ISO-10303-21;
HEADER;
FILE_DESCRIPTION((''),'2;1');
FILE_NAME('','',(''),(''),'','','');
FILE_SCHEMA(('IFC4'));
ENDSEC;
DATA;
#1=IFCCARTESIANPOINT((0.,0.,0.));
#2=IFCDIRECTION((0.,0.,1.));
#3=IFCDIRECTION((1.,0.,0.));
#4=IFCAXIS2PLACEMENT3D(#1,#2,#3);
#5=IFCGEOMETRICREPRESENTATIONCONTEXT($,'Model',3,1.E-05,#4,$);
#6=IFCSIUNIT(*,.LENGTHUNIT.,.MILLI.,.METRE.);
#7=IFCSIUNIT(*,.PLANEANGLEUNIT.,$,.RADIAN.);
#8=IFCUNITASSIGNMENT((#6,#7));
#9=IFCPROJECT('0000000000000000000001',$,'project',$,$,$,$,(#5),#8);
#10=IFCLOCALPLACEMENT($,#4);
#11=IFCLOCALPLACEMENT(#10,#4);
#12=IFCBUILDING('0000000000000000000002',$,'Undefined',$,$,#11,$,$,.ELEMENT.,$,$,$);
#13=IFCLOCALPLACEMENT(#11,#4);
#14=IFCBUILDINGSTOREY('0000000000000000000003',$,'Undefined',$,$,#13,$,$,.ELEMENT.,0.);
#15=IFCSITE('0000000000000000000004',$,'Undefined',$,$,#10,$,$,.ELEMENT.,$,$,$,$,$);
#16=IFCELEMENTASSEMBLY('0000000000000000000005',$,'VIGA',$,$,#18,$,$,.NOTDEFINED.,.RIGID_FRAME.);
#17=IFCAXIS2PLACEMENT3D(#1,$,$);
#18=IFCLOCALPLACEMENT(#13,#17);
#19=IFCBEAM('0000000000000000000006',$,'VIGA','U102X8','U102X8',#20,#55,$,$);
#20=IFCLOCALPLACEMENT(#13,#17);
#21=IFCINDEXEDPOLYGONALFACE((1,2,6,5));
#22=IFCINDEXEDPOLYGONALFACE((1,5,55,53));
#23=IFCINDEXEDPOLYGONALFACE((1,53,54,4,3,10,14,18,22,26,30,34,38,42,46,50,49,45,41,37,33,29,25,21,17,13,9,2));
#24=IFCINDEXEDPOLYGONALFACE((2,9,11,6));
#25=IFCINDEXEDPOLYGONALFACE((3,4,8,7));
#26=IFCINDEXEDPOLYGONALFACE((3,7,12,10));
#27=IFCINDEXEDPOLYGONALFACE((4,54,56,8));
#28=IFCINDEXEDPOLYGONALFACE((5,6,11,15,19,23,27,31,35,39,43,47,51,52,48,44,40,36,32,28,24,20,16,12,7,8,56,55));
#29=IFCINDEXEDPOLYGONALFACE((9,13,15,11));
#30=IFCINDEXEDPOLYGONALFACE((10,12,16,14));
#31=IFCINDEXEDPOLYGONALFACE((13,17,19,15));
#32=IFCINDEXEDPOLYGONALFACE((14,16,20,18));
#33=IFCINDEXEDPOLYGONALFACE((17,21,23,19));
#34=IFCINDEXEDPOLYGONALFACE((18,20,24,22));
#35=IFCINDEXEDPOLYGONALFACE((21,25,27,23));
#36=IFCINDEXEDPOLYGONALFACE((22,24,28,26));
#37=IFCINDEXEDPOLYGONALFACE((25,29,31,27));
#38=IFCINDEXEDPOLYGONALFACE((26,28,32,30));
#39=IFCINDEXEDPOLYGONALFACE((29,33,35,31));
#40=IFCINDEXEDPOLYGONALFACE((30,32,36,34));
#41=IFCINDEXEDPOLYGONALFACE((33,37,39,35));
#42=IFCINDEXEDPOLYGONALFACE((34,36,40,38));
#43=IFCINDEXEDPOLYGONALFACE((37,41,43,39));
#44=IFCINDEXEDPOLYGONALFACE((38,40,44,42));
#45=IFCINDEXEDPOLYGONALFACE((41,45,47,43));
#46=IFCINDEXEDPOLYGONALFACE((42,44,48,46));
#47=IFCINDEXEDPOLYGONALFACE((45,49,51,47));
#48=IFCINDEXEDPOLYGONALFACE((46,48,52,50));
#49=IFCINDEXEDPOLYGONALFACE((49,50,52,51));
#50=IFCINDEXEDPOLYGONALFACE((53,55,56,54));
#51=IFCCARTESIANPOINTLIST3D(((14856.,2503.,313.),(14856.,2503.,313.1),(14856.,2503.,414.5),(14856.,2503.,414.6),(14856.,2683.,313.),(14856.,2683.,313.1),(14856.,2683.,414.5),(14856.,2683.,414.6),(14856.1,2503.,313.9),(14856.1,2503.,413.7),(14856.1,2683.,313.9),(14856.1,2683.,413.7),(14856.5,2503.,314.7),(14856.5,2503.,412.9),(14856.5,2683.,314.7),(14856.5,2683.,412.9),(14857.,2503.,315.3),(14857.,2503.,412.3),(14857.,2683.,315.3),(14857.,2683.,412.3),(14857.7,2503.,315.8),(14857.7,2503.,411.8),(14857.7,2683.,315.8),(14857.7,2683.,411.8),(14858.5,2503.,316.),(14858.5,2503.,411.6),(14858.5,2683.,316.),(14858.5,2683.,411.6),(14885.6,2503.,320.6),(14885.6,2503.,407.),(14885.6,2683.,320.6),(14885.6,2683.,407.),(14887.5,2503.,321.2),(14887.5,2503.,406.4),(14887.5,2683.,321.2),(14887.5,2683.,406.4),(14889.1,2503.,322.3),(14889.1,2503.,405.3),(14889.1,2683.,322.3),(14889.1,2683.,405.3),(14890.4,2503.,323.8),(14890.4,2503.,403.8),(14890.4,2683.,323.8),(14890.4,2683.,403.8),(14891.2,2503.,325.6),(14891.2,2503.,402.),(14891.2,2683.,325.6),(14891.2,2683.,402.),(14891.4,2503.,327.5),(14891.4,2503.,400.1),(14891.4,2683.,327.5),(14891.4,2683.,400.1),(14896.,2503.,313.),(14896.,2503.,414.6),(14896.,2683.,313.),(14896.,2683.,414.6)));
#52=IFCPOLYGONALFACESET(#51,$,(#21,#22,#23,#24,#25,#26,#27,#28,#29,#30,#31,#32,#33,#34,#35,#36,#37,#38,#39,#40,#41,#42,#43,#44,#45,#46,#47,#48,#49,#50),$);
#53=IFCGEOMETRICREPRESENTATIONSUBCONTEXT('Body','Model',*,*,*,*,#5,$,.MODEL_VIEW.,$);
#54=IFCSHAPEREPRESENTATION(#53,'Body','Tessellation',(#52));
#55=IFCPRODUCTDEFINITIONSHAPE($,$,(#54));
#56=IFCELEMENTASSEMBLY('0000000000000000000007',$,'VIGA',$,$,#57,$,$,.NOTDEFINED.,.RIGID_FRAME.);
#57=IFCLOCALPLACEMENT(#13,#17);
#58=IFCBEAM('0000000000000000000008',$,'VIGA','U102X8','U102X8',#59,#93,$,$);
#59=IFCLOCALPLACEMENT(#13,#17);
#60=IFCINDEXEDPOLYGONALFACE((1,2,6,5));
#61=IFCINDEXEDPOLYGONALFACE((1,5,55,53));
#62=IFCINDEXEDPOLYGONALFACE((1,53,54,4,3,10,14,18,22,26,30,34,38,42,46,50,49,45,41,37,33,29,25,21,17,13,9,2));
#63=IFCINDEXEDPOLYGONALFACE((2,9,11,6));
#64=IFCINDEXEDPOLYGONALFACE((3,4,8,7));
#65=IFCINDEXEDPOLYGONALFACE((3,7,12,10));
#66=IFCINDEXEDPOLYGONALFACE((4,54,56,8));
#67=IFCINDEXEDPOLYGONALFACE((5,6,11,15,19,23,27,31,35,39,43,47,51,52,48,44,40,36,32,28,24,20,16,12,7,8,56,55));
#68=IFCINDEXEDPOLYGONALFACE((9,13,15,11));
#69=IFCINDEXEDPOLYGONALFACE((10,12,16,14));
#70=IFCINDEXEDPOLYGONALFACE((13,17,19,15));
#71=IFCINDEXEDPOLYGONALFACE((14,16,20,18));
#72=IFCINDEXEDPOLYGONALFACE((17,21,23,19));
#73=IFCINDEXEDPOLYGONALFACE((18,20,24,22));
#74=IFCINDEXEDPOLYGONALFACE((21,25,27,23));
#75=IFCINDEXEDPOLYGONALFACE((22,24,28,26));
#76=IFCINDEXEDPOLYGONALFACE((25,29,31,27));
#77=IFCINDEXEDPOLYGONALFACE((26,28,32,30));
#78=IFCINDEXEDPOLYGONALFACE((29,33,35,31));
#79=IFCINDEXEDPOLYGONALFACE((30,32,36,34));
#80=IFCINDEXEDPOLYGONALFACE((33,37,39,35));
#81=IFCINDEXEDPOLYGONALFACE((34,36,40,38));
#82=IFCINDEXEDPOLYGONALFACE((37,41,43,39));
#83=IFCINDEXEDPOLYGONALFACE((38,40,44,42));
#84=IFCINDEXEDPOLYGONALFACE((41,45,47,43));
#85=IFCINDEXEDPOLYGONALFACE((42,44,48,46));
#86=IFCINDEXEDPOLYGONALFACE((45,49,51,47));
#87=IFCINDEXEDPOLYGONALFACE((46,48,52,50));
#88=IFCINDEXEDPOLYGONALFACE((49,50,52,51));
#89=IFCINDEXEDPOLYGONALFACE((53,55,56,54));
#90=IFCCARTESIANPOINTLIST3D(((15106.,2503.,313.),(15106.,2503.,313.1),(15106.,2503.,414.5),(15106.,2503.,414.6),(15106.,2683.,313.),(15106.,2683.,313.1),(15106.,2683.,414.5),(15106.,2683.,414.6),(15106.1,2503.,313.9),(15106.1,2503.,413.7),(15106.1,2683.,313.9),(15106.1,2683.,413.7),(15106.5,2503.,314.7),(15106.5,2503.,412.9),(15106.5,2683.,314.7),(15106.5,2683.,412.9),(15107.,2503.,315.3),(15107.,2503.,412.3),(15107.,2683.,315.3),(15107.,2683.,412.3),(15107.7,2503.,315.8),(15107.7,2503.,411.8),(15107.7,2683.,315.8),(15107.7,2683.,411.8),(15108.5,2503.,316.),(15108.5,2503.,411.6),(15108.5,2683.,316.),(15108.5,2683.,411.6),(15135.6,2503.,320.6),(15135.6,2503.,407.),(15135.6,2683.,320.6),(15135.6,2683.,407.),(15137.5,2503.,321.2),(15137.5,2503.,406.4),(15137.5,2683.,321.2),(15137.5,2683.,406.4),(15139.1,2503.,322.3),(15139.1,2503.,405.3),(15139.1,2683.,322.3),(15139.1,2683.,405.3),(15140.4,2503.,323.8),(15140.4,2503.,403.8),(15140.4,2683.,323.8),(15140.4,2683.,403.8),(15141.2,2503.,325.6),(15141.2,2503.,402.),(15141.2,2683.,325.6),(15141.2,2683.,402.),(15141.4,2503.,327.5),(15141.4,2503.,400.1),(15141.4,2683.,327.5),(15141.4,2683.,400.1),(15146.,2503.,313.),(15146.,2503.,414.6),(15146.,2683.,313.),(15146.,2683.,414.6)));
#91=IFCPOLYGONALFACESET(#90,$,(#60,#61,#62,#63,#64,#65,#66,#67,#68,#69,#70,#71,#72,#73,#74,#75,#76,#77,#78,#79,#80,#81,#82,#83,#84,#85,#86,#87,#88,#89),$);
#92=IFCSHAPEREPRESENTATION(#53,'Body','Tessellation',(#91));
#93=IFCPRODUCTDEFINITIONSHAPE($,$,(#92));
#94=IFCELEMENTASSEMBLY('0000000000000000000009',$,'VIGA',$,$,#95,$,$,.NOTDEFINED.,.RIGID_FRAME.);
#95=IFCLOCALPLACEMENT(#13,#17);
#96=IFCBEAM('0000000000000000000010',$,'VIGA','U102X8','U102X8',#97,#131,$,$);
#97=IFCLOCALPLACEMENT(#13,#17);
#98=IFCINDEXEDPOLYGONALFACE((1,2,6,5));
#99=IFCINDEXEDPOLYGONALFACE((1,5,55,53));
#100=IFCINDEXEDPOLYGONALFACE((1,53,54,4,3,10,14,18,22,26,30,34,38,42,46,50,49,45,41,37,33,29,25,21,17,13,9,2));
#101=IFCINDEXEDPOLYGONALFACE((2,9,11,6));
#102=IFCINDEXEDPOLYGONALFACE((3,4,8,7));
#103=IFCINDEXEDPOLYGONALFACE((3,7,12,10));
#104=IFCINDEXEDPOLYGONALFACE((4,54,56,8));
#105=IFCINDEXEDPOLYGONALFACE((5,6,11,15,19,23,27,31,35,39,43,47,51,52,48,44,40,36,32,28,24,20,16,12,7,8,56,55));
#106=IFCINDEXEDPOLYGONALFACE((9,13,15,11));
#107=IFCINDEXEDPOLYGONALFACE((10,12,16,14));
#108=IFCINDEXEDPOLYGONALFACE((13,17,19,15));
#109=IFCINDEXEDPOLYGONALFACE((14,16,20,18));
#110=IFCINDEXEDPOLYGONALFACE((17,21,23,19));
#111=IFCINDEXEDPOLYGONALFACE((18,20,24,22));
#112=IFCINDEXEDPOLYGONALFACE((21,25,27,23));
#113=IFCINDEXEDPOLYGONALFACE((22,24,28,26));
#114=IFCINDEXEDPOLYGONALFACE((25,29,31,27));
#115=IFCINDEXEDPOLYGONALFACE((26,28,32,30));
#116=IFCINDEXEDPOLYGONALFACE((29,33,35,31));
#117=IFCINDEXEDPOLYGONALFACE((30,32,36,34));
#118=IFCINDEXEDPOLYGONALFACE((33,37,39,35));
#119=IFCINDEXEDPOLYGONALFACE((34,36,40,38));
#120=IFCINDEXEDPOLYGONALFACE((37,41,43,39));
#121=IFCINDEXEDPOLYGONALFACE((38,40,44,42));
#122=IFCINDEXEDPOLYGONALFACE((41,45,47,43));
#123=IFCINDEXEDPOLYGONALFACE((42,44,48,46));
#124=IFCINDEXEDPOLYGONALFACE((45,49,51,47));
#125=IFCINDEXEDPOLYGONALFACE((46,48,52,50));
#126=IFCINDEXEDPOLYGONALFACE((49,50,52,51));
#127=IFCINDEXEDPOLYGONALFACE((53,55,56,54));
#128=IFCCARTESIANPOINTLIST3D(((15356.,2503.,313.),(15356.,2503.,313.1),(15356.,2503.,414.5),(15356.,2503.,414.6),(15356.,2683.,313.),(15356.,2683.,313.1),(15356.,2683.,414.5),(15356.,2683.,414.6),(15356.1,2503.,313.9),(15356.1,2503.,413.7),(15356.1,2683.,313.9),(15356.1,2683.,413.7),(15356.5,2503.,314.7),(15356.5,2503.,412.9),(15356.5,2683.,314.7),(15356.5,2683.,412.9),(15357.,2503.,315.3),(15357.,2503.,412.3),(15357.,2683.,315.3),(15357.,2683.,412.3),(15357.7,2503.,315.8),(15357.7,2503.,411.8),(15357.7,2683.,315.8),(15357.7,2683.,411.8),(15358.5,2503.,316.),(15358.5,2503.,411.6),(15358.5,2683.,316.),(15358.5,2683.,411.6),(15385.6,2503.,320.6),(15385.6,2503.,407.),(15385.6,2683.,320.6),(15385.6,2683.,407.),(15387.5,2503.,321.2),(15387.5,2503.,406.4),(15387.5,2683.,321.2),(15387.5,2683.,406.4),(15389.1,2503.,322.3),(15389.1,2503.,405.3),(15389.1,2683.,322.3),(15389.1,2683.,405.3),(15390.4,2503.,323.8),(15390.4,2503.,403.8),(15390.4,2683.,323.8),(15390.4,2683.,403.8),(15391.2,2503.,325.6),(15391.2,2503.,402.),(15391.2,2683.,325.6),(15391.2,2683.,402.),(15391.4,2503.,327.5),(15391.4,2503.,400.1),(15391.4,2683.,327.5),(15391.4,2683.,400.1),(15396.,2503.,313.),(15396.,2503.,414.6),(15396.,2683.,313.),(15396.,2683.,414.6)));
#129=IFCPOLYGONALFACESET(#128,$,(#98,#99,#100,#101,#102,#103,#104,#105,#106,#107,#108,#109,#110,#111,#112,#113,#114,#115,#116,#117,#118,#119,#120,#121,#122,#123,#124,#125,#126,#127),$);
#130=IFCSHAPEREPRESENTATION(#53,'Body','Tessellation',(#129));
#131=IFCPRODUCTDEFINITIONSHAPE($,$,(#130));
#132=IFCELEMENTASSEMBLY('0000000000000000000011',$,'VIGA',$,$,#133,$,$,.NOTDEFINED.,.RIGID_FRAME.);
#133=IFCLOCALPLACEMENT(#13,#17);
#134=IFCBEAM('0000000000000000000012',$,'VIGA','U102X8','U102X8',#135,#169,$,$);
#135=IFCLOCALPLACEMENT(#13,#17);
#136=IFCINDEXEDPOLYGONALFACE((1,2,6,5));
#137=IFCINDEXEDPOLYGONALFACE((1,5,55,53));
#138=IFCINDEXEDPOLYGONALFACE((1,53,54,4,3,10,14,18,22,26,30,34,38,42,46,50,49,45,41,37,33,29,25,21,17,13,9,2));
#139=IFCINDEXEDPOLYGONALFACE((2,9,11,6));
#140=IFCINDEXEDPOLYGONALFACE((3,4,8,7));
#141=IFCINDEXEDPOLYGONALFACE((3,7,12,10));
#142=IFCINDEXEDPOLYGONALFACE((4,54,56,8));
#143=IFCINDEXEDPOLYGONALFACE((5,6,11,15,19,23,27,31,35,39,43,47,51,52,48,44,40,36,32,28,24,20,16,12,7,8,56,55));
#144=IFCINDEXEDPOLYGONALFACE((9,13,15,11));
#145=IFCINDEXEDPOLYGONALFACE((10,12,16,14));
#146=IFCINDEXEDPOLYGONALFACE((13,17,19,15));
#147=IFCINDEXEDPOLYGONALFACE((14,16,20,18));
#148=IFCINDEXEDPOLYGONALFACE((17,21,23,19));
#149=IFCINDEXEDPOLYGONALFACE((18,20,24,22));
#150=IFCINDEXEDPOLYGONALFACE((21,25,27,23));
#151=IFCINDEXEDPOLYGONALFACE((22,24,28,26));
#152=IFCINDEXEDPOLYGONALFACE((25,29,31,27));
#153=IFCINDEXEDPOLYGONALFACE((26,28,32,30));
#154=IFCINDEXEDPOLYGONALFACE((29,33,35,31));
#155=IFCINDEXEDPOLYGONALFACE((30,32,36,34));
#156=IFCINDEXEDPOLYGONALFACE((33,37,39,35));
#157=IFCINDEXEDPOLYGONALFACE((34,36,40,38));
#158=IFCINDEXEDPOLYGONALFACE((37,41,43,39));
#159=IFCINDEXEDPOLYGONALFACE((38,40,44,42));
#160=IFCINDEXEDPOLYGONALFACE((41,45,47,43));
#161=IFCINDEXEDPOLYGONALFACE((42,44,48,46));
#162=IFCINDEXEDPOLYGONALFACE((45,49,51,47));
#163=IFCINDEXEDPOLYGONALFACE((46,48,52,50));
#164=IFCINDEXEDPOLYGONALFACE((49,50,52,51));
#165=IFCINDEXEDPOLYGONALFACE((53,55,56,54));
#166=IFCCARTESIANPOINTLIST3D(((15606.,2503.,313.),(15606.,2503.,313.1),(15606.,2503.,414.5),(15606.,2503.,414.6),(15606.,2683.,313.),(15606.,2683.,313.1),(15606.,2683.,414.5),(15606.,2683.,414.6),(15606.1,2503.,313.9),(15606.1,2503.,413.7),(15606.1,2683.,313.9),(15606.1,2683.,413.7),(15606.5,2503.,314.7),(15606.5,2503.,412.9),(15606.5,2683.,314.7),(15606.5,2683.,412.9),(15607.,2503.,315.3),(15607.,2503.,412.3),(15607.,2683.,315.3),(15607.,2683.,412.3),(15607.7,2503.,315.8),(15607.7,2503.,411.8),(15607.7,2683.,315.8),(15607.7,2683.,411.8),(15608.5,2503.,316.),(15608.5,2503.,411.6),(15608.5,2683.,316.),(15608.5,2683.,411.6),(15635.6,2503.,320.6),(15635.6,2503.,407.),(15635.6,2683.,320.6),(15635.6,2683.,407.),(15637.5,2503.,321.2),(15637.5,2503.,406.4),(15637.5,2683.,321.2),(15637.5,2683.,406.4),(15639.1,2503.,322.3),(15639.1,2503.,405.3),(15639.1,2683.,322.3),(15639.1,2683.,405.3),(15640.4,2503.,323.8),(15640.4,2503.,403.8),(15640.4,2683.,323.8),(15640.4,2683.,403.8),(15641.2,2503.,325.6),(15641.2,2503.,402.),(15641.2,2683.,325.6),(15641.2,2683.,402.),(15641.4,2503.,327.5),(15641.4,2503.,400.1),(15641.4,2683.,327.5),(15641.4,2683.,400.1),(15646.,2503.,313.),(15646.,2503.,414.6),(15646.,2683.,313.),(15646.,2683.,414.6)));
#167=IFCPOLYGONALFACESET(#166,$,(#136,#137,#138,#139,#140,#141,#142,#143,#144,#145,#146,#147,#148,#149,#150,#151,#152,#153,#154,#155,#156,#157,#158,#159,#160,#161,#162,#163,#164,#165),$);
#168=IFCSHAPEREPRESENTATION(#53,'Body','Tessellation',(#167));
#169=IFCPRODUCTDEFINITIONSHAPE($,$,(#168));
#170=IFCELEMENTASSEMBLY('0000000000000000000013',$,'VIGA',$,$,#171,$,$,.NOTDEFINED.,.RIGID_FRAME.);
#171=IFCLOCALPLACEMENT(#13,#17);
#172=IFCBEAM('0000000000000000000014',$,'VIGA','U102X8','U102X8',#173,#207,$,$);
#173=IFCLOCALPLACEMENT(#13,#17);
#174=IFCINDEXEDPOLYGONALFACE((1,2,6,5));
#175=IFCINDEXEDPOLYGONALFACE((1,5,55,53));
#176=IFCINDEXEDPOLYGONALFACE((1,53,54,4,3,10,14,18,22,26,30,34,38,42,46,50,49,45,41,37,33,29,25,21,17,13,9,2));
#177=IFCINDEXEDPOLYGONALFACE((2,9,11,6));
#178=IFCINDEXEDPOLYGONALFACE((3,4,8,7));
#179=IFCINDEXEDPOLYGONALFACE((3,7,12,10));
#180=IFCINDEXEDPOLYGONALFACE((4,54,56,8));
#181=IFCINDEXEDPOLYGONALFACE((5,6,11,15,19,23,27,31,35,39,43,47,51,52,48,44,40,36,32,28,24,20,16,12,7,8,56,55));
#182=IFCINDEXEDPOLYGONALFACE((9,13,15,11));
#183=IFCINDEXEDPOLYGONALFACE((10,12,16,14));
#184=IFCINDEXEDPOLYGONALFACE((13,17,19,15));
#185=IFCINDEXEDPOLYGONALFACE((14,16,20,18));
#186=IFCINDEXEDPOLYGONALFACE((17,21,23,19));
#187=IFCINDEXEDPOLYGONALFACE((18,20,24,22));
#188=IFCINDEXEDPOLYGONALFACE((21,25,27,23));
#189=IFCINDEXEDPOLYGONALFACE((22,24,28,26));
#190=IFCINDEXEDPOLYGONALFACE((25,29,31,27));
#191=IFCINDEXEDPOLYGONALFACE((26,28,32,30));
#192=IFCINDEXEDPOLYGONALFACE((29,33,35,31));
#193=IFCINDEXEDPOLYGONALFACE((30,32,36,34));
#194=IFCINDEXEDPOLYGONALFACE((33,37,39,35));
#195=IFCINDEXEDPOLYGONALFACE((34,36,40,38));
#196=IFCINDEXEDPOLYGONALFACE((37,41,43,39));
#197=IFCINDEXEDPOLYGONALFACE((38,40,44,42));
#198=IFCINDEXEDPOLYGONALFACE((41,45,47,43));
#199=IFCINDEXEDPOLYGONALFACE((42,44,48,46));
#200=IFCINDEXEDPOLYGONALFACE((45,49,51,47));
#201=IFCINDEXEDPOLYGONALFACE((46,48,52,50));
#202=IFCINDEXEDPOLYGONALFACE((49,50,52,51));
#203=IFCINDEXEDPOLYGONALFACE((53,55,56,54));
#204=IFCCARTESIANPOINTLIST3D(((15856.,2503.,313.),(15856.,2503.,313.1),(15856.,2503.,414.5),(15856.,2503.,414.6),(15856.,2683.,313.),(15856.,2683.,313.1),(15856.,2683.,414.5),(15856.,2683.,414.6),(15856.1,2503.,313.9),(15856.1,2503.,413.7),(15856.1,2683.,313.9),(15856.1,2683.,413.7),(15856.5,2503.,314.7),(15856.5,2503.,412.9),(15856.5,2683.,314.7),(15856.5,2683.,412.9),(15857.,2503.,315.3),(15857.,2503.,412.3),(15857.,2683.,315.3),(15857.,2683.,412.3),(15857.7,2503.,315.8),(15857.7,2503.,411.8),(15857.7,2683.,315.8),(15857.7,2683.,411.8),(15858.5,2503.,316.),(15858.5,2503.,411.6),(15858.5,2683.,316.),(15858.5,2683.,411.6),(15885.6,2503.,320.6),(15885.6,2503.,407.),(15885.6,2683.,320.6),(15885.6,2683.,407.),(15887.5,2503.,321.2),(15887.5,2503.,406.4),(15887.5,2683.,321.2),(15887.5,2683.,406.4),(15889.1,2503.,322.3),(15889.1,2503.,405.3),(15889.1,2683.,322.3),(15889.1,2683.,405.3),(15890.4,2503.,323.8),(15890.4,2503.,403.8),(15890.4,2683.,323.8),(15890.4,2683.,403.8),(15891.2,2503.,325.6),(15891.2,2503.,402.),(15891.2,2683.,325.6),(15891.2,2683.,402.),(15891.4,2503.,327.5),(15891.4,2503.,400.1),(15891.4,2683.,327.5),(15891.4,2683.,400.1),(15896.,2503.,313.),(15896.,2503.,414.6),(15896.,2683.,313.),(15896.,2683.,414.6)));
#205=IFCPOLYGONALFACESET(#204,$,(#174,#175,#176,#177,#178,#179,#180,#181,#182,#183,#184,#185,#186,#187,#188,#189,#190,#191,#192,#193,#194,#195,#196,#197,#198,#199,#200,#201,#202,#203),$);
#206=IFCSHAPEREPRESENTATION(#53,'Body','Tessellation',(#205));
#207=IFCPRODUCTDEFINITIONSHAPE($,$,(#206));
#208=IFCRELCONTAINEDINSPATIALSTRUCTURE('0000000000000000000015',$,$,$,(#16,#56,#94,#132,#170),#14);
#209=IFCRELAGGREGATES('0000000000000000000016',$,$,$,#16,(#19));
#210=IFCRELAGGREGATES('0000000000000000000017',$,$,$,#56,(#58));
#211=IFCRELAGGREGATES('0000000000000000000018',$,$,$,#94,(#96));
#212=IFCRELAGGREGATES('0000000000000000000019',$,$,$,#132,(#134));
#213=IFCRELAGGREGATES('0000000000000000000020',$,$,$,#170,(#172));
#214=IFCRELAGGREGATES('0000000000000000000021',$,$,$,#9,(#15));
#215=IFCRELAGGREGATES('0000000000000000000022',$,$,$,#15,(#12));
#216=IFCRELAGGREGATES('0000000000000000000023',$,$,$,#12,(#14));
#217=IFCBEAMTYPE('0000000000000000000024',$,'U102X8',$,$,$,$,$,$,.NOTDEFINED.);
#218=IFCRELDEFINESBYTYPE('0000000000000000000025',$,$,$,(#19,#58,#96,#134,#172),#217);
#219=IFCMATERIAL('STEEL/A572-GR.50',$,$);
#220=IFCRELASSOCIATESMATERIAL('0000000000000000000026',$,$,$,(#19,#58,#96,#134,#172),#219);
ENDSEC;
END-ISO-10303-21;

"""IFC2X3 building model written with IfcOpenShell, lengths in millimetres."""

from ifc_helpers import new_model, si_unit, frame, origin_with_axes, origin_2d_with_axis, place, context, subcontext, project, spatial, u_section, extrude, material, type_object, element, aggregate, save


model = new_model("IFC2X3")

# Units and contexts
model_context = context("Model", 3, precision=1e-05, world=origin_with_axes())
body_context = subcontext(model_context, "Body", "Model", "MODEL_VIEW")
ifc_project = project(units=[si_unit("LENGTHUNIT", "METRE", prefix="MILLI"), si_unit("PLANEANGLEUNIT", "RADIAN")], contexts=[model_context])

# Site, building, storey
site_placement = place(None, origin_with_axes())
site = spatial("IfcSite", under=ifc_project, at=site_placement, Name="Undefined", CompositionType="ELEMENT")
building_placement = place(site_placement, origin_with_axes())
building = spatial("IfcBuilding", under=site, at=building_placement, Name="Undefined", CompositionType="ELEMENT")
storey_placement = place(building_placement, origin_with_axes())
storey = spatial("IfcBuildingStorey", under=building, at=storey_placement, Name="Undefined", CompositionType="ELEMENT", Elevation=0.0)

# Element assemblies, beams
ifc_material = material(Name="STEEL/A572-GR.50")
beam_type = type_object("IfcBeamType", Name="U102X8", PredefinedType="NOTDEFINED")
assembly_1_placement = place(storey_placement, origin_with_axes())
assembly_1 = element("IfcElementAssembly", 1, at=assembly_1_placement, inside=storey, Name="VIGA", AssemblyPlace="NOTDEFINED", PredefinedType="RIGID_FRAME")
beam_1_placement = place(assembly_1_placement, frame((14876.0, 2683.0, 363.8), z_axis=(0.0, 0.0, 1.0), x_axis=(0.0, -1.0, 0.0)))
beam_1 = element("IfcBeam", 2, at=beam_1_placement, type_object=beam_type, material=ifc_material, Name="VIGA", Description="U102X8", ObjectType="U102X8", context=body_context, shape_type="SweptSolid", body=[
    extrude(u_section(Depth=101.6, FlangeWidth=40.0, WebThickness=4.6, FlangeThickness=6.0, FilletRadius=7.0, EdgeRadius=3.0, FlangeSlope=0.16839, at=origin_2d_with_axis()), frame((180.0, 0.0, 0.0), z_axis=(-1.0, 0.0, 0.0), x_axis=(0.0, -1.0, 0.0)), (0.0, 0.0, 1.0), 180.0),
])
aggregate(assembly_1, [beam_1])
assembly_2_placement = place(storey_placement, origin_with_axes())
assembly_2 = element("IfcElementAssembly", 3, at=assembly_2_placement, inside=storey, Name="VIGA", AssemblyPlace="NOTDEFINED", PredefinedType="RIGID_FRAME")
beam_2_placement = place(assembly_2_placement, frame((15126.0, 2683.0, 363.8), z_axis=(0.0, 0.0, 1.0), x_axis=(0.0, -1.0, 0.0)))
beam_2 = element("IfcBeam", 4, at=beam_2_placement, type_object=beam_type, material=ifc_material, Name="VIGA", Description="U102X8", ObjectType="U102X8", context=body_context, shape_type="SweptSolid", body=[
    extrude(u_section(Depth=101.6, FlangeWidth=40.0, WebThickness=4.6, FlangeThickness=6.0, FilletRadius=7.0, EdgeRadius=3.0, FlangeSlope=0.16839, at=origin_2d_with_axis()), frame((180.0, 0.0, 0.0), z_axis=(-1.0, 0.0, 0.0), x_axis=(0.0, -1.0, 0.0)), (0.0, 0.0, 1.0), 180.0),
])
aggregate(assembly_2, [beam_2])
assembly_3_placement = place(storey_placement, origin_with_axes())
assembly_3 = element("IfcElementAssembly", 5, at=assembly_3_placement, inside=storey, Name="VIGA", AssemblyPlace="NOTDEFINED", PredefinedType="RIGID_FRAME")
beam_3_placement = place(assembly_3_placement, frame((15376.0, 2683.0, 363.8), z_axis=(0.0, 0.0, 1.0), x_axis=(0.0, -1.0, 0.0)))
beam_3 = element("IfcBeam", 6, at=beam_3_placement, type_object=beam_type, material=ifc_material, Name="VIGA", Description="U102X8", ObjectType="U102X8", context=body_context, shape_type="SweptSolid", body=[
    extrude(u_section(Depth=101.6, FlangeWidth=40.0, WebThickness=4.6, FlangeThickness=6.0, FilletRadius=7.0, EdgeRadius=3.0, FlangeSlope=0.16839, at=origin_2d_with_axis()), frame((180.0, 0.0, 0.0), z_axis=(-1.0, 0.0, 0.0), x_axis=(0.0, -1.0, 0.0)), (0.0, 0.0, 1.0), 180.0),
])
aggregate(assembly_3, [beam_3])
assembly_4_placement = place(storey_placement, origin_with_axes())
assembly_4 = element("IfcElementAssembly", 7, at=assembly_4_placement, inside=storey, Name="VIGA", AssemblyPlace="NOTDEFINED", PredefinedType="RIGID_FRAME")
beam_4_placement = place(assembly_4_placement, frame((15626.0, 2683.0, 363.8), z_axis=(0.0, 0.0, 1.0), x_axis=(0.0, -1.0, 0.0)))
beam_4 = element("IfcBeam", 8, at=beam_4_placement, type_object=beam_type, material=ifc_material, Name="VIGA", Description="U102X8", ObjectType="U102X8", context=body_context, shape_type="SweptSolid", body=[
    extrude(u_section(Depth=101.6, FlangeWidth=40.0, WebThickness=4.6, FlangeThickness=6.0, FilletRadius=7.0, EdgeRadius=3.0, FlangeSlope=0.16839, at=origin_2d_with_axis()), frame((180.0, 0.0, 0.0), z_axis=(-1.0, 0.0, 0.0), x_axis=(0.0, -1.0, 0.0)), (0.0, 0.0, 1.0), 180.0),
])
aggregate(assembly_4, [beam_4])
assembly_5_placement = place(storey_placement, origin_with_axes())
assembly_5 = element("IfcElementAssembly", 9, at=assembly_5_placement, inside=storey, Name="VIGA", AssemblyPlace="NOTDEFINED", PredefinedType="RIGID_FRAME")
beam_5_placement = place(assembly_5_placement, frame((15876.0, 2683.0, 363.8), z_axis=(0.0, 0.0, 1.0), x_axis=(0.0, -1.0, 0.0)))
beam_5 = element("IfcBeam", 10, at=beam_5_placement, type_object=beam_type, material=ifc_material, Name="VIGA", Description="U102X8", ObjectType="U102X8", context=body_context, shape_type="SweptSolid", body=[
    extrude(u_section(Depth=101.6, FlangeWidth=40.0, WebThickness=4.6, FlangeThickness=6.0, FilletRadius=7.0, EdgeRadius=3.0, FlangeSlope=0.16839, at=origin_2d_with_axis()), frame((180.0, 0.0, 0.0), z_axis=(-1.0, 0.0, 0.0), x_axis=(0.0, -1.0, 0.0)), (0.0, 0.0, 1.0), 180.0),
])
aggregate(assembly_5, [beam_5])

save(model, "model.ifc")
